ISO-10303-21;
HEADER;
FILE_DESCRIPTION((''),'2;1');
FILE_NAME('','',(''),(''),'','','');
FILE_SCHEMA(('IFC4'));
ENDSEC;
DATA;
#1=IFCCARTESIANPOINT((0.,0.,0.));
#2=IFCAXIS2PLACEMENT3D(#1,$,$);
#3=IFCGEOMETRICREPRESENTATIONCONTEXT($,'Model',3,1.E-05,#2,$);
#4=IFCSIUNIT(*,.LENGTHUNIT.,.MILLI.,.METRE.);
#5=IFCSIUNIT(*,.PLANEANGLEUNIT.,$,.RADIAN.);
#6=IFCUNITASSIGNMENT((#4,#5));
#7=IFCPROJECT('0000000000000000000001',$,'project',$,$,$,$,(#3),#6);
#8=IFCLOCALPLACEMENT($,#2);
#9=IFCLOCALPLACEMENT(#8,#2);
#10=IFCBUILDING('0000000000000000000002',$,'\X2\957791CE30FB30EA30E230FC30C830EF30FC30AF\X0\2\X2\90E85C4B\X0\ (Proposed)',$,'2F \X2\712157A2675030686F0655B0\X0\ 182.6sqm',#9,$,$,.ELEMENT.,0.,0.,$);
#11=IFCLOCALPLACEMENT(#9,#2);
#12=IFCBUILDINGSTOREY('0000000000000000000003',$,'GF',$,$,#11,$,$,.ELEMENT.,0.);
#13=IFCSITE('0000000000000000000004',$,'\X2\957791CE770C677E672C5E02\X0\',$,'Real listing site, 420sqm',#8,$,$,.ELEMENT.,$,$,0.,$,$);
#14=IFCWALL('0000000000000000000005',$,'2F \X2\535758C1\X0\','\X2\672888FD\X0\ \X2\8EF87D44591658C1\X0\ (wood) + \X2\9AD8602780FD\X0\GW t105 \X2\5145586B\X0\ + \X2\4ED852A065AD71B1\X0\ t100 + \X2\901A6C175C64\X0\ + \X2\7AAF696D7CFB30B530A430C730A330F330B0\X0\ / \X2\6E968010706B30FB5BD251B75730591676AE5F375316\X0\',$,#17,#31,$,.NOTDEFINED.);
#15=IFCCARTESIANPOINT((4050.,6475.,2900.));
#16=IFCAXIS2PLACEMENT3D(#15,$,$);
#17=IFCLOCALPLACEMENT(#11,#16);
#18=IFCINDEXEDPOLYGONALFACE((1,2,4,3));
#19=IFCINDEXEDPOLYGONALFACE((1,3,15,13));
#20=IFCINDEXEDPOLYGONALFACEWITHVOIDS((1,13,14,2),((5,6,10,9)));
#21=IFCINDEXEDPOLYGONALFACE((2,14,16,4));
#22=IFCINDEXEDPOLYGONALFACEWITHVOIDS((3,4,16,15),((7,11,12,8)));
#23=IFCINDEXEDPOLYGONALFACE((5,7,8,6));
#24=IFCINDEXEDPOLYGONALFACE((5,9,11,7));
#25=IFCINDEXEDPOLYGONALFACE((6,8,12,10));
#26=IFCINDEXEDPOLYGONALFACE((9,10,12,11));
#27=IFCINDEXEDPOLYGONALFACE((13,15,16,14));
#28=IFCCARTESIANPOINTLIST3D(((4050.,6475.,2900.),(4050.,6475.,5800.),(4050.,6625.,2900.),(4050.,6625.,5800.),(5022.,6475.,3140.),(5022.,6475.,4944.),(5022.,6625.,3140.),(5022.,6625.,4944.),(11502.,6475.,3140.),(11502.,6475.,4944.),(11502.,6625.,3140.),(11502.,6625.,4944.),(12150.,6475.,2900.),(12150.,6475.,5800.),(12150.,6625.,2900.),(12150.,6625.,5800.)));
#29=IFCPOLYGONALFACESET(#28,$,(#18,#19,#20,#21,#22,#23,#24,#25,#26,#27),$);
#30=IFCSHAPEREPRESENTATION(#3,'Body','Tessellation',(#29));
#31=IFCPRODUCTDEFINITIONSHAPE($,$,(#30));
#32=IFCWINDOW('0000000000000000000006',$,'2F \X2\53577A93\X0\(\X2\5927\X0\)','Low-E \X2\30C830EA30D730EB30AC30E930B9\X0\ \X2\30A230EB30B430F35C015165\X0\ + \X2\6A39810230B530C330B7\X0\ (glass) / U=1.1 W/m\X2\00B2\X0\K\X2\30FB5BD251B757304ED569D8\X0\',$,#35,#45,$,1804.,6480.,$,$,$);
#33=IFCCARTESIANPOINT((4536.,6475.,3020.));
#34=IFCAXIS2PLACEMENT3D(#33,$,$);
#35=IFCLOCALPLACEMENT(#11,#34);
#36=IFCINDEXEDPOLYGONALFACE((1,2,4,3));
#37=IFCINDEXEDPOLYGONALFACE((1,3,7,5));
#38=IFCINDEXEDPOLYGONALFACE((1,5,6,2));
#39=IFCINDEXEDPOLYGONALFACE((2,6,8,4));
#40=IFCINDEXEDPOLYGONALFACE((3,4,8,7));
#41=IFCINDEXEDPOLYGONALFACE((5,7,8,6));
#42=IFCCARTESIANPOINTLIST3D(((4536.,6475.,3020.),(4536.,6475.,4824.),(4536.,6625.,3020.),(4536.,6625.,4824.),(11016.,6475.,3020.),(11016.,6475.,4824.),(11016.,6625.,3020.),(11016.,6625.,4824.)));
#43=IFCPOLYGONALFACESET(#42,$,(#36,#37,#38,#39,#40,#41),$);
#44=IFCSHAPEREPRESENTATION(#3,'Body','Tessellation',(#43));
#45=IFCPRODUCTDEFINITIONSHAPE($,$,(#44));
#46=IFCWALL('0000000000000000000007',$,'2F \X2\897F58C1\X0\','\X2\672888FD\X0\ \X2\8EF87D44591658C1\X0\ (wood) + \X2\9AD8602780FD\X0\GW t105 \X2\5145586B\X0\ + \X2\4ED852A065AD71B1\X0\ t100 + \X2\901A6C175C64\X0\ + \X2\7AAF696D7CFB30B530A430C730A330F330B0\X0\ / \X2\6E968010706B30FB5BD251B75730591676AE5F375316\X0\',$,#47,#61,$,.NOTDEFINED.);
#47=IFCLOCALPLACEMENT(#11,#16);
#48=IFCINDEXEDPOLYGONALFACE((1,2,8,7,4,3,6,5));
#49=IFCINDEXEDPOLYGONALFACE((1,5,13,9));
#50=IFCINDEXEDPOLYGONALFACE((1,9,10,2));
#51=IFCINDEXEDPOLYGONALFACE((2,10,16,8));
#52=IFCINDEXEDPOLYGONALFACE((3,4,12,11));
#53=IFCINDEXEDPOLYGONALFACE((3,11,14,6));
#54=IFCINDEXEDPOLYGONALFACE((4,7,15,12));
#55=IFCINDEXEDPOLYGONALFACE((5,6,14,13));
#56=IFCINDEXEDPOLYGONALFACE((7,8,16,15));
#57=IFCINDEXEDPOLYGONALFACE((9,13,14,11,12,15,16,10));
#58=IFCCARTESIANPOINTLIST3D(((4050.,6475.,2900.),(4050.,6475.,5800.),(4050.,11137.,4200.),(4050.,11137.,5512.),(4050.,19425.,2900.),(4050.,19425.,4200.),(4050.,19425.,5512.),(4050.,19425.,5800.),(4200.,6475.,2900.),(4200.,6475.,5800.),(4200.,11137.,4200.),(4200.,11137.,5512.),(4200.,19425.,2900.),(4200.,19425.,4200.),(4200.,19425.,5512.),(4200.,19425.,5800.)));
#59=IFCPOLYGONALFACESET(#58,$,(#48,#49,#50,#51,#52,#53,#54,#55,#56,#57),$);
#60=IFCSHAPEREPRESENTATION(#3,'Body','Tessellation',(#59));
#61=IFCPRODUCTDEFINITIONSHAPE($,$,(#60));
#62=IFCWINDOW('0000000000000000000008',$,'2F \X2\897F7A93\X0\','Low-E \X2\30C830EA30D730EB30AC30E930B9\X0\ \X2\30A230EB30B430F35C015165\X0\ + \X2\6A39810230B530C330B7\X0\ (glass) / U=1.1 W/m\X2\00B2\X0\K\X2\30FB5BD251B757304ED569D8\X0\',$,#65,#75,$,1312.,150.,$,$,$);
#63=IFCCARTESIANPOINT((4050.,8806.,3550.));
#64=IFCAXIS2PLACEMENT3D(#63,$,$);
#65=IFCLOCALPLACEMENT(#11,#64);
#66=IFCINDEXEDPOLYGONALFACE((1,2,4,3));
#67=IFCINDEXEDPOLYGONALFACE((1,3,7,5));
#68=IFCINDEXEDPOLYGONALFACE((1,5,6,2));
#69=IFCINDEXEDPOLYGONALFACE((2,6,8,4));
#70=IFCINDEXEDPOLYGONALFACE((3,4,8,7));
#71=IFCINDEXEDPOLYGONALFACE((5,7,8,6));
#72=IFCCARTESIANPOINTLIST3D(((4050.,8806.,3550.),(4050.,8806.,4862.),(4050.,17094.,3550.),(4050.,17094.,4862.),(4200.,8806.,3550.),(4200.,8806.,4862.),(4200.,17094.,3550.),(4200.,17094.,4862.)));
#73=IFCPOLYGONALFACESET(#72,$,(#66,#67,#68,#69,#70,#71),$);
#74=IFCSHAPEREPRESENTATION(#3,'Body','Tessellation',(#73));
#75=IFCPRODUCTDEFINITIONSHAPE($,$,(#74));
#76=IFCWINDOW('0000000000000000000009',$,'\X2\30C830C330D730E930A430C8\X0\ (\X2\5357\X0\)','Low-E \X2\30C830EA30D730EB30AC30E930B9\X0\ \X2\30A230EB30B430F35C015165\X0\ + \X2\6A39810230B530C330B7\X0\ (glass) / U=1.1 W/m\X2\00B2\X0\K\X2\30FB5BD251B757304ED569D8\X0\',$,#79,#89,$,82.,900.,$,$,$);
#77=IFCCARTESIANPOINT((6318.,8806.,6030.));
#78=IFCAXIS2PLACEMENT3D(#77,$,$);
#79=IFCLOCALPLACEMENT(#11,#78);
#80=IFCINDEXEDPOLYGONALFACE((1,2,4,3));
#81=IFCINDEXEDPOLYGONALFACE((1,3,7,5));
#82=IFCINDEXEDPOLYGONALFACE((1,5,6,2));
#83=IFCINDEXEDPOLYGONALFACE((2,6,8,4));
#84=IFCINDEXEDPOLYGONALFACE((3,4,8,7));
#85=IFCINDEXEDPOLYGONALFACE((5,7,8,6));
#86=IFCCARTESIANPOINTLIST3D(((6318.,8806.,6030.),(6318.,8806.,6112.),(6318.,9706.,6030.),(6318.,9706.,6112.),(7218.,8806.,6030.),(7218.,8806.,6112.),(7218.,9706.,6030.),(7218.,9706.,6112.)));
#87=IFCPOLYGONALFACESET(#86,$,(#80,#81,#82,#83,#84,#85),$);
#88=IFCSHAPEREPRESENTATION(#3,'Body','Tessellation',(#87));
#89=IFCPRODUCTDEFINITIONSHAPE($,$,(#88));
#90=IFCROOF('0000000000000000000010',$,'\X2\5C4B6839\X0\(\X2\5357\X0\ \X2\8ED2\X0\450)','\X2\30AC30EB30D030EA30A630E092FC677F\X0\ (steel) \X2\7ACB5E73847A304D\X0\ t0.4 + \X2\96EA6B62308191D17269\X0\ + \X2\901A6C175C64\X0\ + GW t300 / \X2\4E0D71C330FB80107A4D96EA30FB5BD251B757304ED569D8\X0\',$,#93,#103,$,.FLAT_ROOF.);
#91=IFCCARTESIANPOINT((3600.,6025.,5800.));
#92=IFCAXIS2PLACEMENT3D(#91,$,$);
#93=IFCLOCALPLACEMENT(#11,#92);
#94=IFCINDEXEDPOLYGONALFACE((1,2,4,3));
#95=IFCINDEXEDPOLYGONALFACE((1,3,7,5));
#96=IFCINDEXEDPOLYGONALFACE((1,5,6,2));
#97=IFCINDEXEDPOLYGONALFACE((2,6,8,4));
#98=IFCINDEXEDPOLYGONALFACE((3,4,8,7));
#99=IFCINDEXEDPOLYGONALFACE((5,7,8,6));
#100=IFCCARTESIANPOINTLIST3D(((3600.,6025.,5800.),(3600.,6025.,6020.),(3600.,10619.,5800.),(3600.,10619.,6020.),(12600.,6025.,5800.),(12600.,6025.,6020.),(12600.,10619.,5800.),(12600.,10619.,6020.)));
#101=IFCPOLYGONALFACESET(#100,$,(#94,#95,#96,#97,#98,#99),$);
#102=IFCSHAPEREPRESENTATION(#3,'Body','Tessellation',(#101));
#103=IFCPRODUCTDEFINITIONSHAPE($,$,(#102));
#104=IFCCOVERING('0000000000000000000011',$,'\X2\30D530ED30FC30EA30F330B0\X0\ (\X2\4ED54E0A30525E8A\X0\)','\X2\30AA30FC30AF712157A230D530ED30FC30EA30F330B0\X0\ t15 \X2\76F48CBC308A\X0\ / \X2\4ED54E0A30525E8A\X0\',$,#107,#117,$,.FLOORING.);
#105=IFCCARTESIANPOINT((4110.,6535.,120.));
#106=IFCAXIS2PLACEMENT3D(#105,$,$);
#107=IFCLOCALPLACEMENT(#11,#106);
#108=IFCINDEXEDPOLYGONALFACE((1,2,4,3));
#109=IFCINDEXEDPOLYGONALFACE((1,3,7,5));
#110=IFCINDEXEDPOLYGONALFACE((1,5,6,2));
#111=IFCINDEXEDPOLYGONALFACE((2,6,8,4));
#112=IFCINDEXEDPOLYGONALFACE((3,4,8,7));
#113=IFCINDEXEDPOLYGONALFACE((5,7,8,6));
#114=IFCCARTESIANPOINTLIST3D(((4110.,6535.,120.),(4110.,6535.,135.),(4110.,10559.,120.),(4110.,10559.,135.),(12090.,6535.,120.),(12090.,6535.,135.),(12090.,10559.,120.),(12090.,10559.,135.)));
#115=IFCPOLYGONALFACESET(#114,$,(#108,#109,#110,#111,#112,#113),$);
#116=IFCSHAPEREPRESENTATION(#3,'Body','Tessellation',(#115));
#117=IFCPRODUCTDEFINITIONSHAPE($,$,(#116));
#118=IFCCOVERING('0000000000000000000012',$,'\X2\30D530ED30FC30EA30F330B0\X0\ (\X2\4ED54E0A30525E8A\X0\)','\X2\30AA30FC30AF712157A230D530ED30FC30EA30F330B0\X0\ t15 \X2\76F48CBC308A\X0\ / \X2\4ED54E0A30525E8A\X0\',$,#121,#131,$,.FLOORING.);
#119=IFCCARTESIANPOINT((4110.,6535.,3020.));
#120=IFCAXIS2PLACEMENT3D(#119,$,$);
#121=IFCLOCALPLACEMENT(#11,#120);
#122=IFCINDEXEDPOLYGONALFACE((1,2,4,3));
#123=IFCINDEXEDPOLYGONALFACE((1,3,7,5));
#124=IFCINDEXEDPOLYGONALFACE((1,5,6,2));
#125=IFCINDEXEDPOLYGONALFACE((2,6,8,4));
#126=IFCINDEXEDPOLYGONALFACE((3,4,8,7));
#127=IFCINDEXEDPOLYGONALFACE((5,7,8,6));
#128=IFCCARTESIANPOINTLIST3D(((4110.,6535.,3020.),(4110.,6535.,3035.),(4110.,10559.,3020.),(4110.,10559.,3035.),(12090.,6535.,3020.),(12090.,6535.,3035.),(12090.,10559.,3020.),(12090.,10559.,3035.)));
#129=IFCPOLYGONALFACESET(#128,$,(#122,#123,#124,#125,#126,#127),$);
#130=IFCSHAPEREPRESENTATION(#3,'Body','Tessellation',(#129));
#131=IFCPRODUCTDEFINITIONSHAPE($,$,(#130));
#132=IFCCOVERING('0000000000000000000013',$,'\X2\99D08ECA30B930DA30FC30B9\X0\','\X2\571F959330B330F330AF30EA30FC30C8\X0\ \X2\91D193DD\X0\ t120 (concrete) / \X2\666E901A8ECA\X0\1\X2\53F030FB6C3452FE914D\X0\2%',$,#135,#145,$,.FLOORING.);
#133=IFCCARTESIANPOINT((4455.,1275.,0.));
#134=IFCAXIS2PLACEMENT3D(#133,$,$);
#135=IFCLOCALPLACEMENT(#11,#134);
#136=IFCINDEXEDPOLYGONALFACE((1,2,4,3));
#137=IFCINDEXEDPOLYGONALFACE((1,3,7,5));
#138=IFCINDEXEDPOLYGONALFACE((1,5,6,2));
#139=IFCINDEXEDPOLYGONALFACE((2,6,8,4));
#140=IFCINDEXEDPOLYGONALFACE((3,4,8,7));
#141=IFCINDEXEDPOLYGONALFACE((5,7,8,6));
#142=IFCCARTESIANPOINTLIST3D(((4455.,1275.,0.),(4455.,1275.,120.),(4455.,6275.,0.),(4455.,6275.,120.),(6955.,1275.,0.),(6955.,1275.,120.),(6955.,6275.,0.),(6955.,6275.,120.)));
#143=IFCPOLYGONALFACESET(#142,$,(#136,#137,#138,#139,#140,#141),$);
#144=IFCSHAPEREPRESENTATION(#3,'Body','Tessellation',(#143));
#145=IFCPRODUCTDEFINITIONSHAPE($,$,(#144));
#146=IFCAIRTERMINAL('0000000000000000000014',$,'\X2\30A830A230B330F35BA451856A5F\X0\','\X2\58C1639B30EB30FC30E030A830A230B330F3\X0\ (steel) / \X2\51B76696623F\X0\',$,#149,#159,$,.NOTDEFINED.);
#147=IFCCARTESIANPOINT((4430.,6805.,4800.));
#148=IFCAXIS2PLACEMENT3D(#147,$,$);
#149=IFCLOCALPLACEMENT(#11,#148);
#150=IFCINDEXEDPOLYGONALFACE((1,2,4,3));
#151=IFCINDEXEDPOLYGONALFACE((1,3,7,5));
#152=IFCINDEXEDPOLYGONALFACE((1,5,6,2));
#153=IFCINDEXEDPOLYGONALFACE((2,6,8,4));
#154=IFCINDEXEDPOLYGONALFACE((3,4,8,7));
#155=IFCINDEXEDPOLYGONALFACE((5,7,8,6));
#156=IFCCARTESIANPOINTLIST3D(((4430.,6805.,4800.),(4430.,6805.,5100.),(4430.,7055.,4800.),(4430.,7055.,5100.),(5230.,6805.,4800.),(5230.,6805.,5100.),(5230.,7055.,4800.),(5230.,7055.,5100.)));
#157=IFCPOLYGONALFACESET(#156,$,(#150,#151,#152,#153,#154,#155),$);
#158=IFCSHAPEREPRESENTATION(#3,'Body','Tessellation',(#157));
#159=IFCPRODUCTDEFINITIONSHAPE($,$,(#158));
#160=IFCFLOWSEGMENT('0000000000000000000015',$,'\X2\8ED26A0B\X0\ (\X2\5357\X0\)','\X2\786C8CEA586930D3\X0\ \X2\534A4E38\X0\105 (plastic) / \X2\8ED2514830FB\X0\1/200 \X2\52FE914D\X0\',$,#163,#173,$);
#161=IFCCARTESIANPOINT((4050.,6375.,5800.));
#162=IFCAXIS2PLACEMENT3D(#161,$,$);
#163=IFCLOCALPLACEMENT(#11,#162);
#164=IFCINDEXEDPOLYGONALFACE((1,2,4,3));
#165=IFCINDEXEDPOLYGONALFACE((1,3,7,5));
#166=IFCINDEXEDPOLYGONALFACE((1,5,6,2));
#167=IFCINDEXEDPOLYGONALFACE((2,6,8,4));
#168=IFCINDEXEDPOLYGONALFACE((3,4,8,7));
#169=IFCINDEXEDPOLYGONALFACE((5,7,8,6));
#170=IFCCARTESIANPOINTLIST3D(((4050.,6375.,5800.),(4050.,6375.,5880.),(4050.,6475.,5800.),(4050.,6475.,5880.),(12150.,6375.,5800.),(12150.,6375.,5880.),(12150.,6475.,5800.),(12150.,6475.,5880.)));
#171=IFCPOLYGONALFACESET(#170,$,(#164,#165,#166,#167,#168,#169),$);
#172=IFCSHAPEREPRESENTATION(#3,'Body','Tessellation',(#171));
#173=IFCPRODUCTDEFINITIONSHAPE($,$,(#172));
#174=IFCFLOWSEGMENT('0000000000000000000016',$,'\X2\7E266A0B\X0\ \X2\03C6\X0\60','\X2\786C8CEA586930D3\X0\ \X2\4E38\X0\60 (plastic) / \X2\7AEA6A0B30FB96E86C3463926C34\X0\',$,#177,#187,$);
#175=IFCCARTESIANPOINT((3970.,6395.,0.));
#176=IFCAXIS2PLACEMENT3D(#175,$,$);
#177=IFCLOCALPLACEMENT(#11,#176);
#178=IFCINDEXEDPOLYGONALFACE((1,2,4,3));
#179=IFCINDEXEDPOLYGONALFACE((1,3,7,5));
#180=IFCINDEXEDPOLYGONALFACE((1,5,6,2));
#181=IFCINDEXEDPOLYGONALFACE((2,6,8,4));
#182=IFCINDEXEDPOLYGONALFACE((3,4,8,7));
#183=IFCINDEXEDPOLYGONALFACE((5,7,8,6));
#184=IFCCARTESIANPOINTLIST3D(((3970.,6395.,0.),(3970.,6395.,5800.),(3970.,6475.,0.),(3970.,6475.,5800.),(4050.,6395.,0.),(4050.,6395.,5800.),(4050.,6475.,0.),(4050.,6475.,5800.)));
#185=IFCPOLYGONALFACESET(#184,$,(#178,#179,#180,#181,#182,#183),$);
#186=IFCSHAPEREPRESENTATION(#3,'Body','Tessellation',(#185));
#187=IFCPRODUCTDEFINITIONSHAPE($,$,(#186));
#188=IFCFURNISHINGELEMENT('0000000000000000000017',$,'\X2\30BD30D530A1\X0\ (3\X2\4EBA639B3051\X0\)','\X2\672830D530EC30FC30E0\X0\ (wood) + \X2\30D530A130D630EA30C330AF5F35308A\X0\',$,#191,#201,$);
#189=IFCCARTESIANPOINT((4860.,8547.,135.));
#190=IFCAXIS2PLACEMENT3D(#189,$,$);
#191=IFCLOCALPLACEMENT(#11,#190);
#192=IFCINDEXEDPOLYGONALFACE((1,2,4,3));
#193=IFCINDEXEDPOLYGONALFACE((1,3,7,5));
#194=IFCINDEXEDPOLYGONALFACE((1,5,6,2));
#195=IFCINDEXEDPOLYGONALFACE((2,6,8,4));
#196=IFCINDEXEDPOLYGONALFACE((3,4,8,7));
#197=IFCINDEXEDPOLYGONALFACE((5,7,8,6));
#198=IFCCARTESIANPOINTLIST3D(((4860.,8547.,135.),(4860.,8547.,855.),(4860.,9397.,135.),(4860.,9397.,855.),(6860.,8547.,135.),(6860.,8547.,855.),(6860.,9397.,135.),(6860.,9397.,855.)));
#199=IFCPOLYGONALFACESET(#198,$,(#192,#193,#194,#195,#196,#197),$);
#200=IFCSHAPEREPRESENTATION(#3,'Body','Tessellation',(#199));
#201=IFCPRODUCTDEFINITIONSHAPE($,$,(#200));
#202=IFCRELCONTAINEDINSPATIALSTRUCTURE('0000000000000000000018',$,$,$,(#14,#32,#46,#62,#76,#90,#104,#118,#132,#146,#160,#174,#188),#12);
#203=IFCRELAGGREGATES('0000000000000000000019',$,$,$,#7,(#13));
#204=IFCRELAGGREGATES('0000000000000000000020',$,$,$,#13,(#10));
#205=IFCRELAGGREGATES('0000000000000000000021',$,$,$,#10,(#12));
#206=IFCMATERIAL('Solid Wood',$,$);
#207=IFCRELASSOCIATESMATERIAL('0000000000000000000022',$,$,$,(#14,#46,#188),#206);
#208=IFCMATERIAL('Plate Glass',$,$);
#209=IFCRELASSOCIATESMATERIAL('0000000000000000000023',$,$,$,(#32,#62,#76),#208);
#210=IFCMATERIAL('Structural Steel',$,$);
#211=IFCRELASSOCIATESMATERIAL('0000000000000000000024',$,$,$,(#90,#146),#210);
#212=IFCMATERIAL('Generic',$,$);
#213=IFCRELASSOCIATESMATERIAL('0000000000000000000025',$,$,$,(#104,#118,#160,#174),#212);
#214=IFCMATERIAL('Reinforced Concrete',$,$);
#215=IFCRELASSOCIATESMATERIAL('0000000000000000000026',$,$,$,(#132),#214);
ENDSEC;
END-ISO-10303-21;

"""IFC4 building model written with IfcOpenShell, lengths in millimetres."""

from ifc_helpers import new_model, si_unit, frame, frame_2d, origin, place, context, project, spatial, rectangle, extrude, material, element, fill, save


model = new_model("IFC4")

# Units and contexts
model_context = context("Model", 3, precision=1e-05, world=origin())
ifc_project = project(units=[si_unit("LENGTHUNIT", "METRE", prefix="MILLI"), si_unit("PLANEANGLEUNIT", "RADIAN")], contexts=[model_context])

# Site, building, storey
site_placement = place(None, origin())
site = spatial("IfcSite", under=ifc_project, at=site_placement, Name="長野県松本市", ObjectType="Real listing site, 420sqm", CompositionType="ELEMENT", RefElevation=0.0)
building_placement = place(site_placement, origin())
building = spatial("IfcBuilding", under=site, at=building_placement, Name="長野・リモートワーク2部屋 (Proposed)", ObjectType="2F 無垢材と漆喰 182.6sqm", CompositionType="ELEMENT", ElevationOfRefHeight=0.0, ElevationOfTerrain=0.0)
storey_placement = place(building_placement, origin())
storey = spatial("IfcBuildingStorey", under=building, at=storey_placement, Name="GF", CompositionType="ELEMENT", Elevation=0.0)

# Shared definitions
ifc_material_1 = material(Name="Solid Wood")

# Shared definitions
ifc_material_2 = material(Name="Reinforced Concrete")

# Shared definitions
ifc_material_3 = material(Name="Plate Glass")

# Walls, openings, windows
wall_1_placement = place(storey_placement, frame((4050.0, 6475.0, 2900.0)))
wall_1 = element("IfcWall", 1, at=wall_1_placement, inside=storey, material=ifc_material_1, Name="2F 南壁", Description="木製 軸組外壁 (wood) + 高性能GW t105 充填 + 付加断熱 t100 + 通気層 + 窯業系サイディング / 準耐火・寒冷地外皮強化", PredefinedType="NOTDEFINED", context=model_context, shape_type="SweptSolid", body=[
    extrude(rectangle(XDim=8100.0, YDim=150.0, at=frame_2d((4050.0, 75.0))), frame((4050.0, 6475.0, 2900.0)), (0.0, 0.0, 1.0), 2900.0),
])
opening_1_placement = place(storey_placement, frame((4536.0, 6475.0, 3020.0)))
opening_1 = element("IfcOpeningElement", 2, at=opening_1_placement, cuts=wall_1, PredefinedType="NOTDEFINED", context=model_context, shape_type="SweptSolid", body=[
    extrude(rectangle(XDim=6480.0, YDim=150.0, at=frame_2d((3240.0, 75.0))), frame((4536.0, 6475.0, 3020.0)), (0.0, 0.0, 1.0), 1804.0),
])
window_1_placement = place(storey_placement, frame((4536.0, 6475.0, 3020.0)))
window_1 = element("IfcWindow", 3, at=window_1_placement, inside=storey, material=ifc_material_3, Name="2F 南窓(大)", Description="Low-E トリプルガラス アルゴン封入 + 樹脂サッシ (glass) / U=1.1 W/m²K・寒冷地仕様", OverallHeight=1804.0, OverallWidth=6480.0, context=model_context, shape_type="SweptSolid", body=[
    extrude(rectangle(XDim=6480.0, YDim=150.0, at=frame_2d((3240.0, 75.0))), frame((4536.0, 6475.0, 3020.0)), (0.0, 0.0, 1.0), 1804.0),
])
fill(opening_1, window_1)
wall_2_placement = place(storey_placement, frame((4050.0, 6475.0, 2900.0)))
wall_2 = element("IfcWall", 4, at=wall_2_placement, inside=storey, material=ifc_material_1, Name="2F 西壁", Description="木製 軸組外壁 (wood) + 高性能GW t105 充填 + 付加断熱 t100 + 通気層 + 窯業系サイディング / 準耐火・寒冷地外皮強化", PredefinedType="NOTDEFINED", context=model_context, shape_type="SweptSolid", body=[
    extrude(rectangle(XDim=150.0, YDim=12950.0, at=frame_2d((75.0, 6475.0))), frame((4050.0, 6475.0, 2900.0)), (0.0, 0.0, 1.0), 2900.0),
])
opening_2_placement = place(storey_placement, frame((4050.0, 8806.0, 3550.0)))
opening_2 = element("IfcOpeningElement", 5, at=opening_2_placement, cuts=wall_2, PredefinedType="NOTDEFINED", context=model_context, shape_type="SweptSolid", body=[
    extrude(rectangle(XDim=150.0, YDim=8288.0, at=frame_2d((75.0, 4144.0))), frame((4050.0, 8806.0, 3550.0)), (0.0, 0.0, 1.0), 1312.0),
])
window_2_placement = place(storey_placement, frame((4050.0, 8806.0, 3550.0)))
window_2 = element("IfcWindow", 6, at=window_2_placement, inside=storey, material=ifc_material_3, Name="2F 西窓", Description="Low-E トリプルガラス アルゴン封入 + 樹脂サッシ (glass) / U=1.1 W/m²K・寒冷地仕様", OverallHeight=1312.0, OverallWidth=150.0, context=model_context, shape_type="SweptSolid", body=[
    extrude(rectangle(XDim=150.0, YDim=8288.0, at=frame_2d((75.0, 4144.0))), frame((4050.0, 8806.0, 3550.0)), (0.0, 0.0, 1.0), 1312.0),
])
fill(opening_2, window_2)

# Window
window_3_placement = place(storey_placement, frame((6318.0, 8806.0, 6030.0)))
element("IfcWindow", 7, at=window_3_placement, inside=storey, material=ifc_material_3, Name="トップライト (南)", Description="Low-E トリプルガラス アルゴン封入 + 樹脂サッシ (glass) / U=1.1 W/m²K・寒冷地仕様", OverallHeight=82.0, OverallWidth=900.0, context=model_context, shape_type="SweptSolid", body=[
    extrude(rectangle(XDim=900.0, YDim=900.0, at=frame_2d((450.0, 450.0))), frame((6318.0, 8806.0, 6030.0)), (0.0, 0.0, 1.0), 82.0),
])

# Roof
ifc_material_4 = material(Name="Structural Steel")
for number, where, name in (
    (8, (3600.0, 6025.0, 5800.0), "屋根(南 軒450)"),
):
    element("IfcRoof", number, at=place(storey_placement, frame(where)), inside=storey, material=ifc_material_4, Name=name, Description="ガルバリウム鋼板 (steel) 立平葺き t0.4 + 雪止め金物 + 通気層 + GW t300 / 不燃・耐積雪・寒冷地仕様", PredefinedType="FLAT_ROOF", context=model_context, shape_type="SweptSolid", body=[
        extrude(rectangle(XDim=9000.0, YDim=4594.0, at=frame_2d((4500.0, 2297.0))), frame((3600.0, 6025.0, 5800.0)), (0.0, 0.0, 1.0), 220.0),
    ])

# Coverings
ifc_material_5 = material(Name="Generic")
covering_1_placement = place(storey_placement, frame((4110.0, 6535.0, 120.0)))
element("IfcCovering", 9, at=covering_1_placement, inside=storey, material=ifc_material_5, Name="フローリング (仕上げ床)", Description="オーク無垢フローリング t15 直貼り / 仕上げ床", PredefinedType="FLOORING", context=model_context, shape_type="SweptSolid", body=[
    extrude(rectangle(XDim=7980.0, YDim=4024.0, at=frame_2d((3990.0, 2012.0))), frame((4110.0, 6535.0, 120.0)), (0.0, 0.0, 1.0), 15.0),
])
covering_2_placement = place(storey_placement, frame((4110.0, 6535.0, 3020.0)))
element("IfcCovering", 10, at=covering_2_placement, inside=storey, material=ifc_material_5, Name="フローリング (仕上げ床)", Description="オーク無垢フローリング t15 直貼り / 仕上げ床", PredefinedType="FLOORING", context=model_context, shape_type="SweptSolid", body=[
    extrude(rectangle(XDim=7980.0, YDim=4024.0, at=frame_2d((3990.0, 2012.0))), frame((4110.0, 6535.0, 3020.0)), (0.0, 0.0, 1.0), 15.0),
])
covering_3_placement = place(storey_placement, frame((4455.0, 1275.0, 0.0)))
element("IfcCovering", 11, at=covering_3_placement, inside=storey, material=ifc_material_2, Name="駐車スペース", Description="土間コンクリート 金鏝 t120 (concrete) / 普通車1台・水勾配2%", PredefinedType="FLOORING", context=model_context, shape_type="SweptSolid", body=[
    extrude(rectangle(XDim=2500.0, YDim=5000.0, at=frame_2d((1250.0, 2500.0))), frame((4455.0, 1275.0, 0.0)), (0.0, 0.0, 1.0), 120.0),
])

# Air terminal
air_terminal_placement = place(storey_placement, frame((4430.0, 6805.0, 4800.0)))
element("IfcAirTerminal", 12, at=air_terminal_placement, inside=storey, material=ifc_material_4, Name="エアコン室内機", Description="壁掛ルームエアコン (steel) / 冷暖房", PredefinedType="NOTDEFINED", context=model_context, shape_type="SweptSolid", body=[
    extrude(rectangle(XDim=800.0, YDim=250.0, at=frame_2d((400.0, 125.0))), frame((4430.0, 6805.0, 4800.0)), (0.0, 0.0, 1.0), 300.0),
])

# Flow segments
flow_segment_1_placement = place(storey_placement, frame((4050.0, 6375.0, 5800.0)))
element("IfcFlowSegment", 13, at=flow_segment_1_placement, inside=storey, material=ifc_material_5, Name="軒樋 (南)", Description="硬質塩ビ 半丸105 (plastic) / 軒先・1/200 勾配", context=model_context, shape_type="SweptSolid", body=[
    extrude(rectangle(XDim=8100.0, YDim=100.0, at=frame_2d((4050.0, 50.0))), frame((4050.0, 6375.0, 5800.0)), (0.0, 0.0, 1.0), 80.0),
])
flow_segment_2_placement = place(storey_placement, frame((3970.0, 6395.0, 0.0)))
element("IfcFlowSegment", 14, at=flow_segment_2_placement, inside=storey, material=ifc_material_5, Name="縦樋 φ60", Description="硬質塩ビ 丸60 (plastic) / 竪樋・雨水排水", context=model_context, shape_type="SweptSolid", body=[
    extrude(rectangle(XDim=80.0, YDim=80.0, at=frame_2d((40.0, 40.0))), frame((3970.0, 6395.0, 0.0)), (0.0, 0.0, 1.0), 5800.0),
])

# Furnishing element
furnishing_1_placement = place(storey_placement, frame((4860.0, 8547.0, 135.0)))
element("IfcFurnishingElement", 15, at=furnishing_1_placement, inside=storey, material=ifc_material_1, Name="ソファ (3人掛け)", Description="木フレーム (wood) + ファブリック張り", context=model_context, shape_type="SweptSolid", body=[
    extrude(rectangle(XDim=2000.0, YDim=850.0, at=frame_2d((1000.0, 425.0))), frame((4860.0, 8547.0, 135.0)), (0.0, 0.0, 1.0), 720.0),
])

save(model, "model.ifc")
